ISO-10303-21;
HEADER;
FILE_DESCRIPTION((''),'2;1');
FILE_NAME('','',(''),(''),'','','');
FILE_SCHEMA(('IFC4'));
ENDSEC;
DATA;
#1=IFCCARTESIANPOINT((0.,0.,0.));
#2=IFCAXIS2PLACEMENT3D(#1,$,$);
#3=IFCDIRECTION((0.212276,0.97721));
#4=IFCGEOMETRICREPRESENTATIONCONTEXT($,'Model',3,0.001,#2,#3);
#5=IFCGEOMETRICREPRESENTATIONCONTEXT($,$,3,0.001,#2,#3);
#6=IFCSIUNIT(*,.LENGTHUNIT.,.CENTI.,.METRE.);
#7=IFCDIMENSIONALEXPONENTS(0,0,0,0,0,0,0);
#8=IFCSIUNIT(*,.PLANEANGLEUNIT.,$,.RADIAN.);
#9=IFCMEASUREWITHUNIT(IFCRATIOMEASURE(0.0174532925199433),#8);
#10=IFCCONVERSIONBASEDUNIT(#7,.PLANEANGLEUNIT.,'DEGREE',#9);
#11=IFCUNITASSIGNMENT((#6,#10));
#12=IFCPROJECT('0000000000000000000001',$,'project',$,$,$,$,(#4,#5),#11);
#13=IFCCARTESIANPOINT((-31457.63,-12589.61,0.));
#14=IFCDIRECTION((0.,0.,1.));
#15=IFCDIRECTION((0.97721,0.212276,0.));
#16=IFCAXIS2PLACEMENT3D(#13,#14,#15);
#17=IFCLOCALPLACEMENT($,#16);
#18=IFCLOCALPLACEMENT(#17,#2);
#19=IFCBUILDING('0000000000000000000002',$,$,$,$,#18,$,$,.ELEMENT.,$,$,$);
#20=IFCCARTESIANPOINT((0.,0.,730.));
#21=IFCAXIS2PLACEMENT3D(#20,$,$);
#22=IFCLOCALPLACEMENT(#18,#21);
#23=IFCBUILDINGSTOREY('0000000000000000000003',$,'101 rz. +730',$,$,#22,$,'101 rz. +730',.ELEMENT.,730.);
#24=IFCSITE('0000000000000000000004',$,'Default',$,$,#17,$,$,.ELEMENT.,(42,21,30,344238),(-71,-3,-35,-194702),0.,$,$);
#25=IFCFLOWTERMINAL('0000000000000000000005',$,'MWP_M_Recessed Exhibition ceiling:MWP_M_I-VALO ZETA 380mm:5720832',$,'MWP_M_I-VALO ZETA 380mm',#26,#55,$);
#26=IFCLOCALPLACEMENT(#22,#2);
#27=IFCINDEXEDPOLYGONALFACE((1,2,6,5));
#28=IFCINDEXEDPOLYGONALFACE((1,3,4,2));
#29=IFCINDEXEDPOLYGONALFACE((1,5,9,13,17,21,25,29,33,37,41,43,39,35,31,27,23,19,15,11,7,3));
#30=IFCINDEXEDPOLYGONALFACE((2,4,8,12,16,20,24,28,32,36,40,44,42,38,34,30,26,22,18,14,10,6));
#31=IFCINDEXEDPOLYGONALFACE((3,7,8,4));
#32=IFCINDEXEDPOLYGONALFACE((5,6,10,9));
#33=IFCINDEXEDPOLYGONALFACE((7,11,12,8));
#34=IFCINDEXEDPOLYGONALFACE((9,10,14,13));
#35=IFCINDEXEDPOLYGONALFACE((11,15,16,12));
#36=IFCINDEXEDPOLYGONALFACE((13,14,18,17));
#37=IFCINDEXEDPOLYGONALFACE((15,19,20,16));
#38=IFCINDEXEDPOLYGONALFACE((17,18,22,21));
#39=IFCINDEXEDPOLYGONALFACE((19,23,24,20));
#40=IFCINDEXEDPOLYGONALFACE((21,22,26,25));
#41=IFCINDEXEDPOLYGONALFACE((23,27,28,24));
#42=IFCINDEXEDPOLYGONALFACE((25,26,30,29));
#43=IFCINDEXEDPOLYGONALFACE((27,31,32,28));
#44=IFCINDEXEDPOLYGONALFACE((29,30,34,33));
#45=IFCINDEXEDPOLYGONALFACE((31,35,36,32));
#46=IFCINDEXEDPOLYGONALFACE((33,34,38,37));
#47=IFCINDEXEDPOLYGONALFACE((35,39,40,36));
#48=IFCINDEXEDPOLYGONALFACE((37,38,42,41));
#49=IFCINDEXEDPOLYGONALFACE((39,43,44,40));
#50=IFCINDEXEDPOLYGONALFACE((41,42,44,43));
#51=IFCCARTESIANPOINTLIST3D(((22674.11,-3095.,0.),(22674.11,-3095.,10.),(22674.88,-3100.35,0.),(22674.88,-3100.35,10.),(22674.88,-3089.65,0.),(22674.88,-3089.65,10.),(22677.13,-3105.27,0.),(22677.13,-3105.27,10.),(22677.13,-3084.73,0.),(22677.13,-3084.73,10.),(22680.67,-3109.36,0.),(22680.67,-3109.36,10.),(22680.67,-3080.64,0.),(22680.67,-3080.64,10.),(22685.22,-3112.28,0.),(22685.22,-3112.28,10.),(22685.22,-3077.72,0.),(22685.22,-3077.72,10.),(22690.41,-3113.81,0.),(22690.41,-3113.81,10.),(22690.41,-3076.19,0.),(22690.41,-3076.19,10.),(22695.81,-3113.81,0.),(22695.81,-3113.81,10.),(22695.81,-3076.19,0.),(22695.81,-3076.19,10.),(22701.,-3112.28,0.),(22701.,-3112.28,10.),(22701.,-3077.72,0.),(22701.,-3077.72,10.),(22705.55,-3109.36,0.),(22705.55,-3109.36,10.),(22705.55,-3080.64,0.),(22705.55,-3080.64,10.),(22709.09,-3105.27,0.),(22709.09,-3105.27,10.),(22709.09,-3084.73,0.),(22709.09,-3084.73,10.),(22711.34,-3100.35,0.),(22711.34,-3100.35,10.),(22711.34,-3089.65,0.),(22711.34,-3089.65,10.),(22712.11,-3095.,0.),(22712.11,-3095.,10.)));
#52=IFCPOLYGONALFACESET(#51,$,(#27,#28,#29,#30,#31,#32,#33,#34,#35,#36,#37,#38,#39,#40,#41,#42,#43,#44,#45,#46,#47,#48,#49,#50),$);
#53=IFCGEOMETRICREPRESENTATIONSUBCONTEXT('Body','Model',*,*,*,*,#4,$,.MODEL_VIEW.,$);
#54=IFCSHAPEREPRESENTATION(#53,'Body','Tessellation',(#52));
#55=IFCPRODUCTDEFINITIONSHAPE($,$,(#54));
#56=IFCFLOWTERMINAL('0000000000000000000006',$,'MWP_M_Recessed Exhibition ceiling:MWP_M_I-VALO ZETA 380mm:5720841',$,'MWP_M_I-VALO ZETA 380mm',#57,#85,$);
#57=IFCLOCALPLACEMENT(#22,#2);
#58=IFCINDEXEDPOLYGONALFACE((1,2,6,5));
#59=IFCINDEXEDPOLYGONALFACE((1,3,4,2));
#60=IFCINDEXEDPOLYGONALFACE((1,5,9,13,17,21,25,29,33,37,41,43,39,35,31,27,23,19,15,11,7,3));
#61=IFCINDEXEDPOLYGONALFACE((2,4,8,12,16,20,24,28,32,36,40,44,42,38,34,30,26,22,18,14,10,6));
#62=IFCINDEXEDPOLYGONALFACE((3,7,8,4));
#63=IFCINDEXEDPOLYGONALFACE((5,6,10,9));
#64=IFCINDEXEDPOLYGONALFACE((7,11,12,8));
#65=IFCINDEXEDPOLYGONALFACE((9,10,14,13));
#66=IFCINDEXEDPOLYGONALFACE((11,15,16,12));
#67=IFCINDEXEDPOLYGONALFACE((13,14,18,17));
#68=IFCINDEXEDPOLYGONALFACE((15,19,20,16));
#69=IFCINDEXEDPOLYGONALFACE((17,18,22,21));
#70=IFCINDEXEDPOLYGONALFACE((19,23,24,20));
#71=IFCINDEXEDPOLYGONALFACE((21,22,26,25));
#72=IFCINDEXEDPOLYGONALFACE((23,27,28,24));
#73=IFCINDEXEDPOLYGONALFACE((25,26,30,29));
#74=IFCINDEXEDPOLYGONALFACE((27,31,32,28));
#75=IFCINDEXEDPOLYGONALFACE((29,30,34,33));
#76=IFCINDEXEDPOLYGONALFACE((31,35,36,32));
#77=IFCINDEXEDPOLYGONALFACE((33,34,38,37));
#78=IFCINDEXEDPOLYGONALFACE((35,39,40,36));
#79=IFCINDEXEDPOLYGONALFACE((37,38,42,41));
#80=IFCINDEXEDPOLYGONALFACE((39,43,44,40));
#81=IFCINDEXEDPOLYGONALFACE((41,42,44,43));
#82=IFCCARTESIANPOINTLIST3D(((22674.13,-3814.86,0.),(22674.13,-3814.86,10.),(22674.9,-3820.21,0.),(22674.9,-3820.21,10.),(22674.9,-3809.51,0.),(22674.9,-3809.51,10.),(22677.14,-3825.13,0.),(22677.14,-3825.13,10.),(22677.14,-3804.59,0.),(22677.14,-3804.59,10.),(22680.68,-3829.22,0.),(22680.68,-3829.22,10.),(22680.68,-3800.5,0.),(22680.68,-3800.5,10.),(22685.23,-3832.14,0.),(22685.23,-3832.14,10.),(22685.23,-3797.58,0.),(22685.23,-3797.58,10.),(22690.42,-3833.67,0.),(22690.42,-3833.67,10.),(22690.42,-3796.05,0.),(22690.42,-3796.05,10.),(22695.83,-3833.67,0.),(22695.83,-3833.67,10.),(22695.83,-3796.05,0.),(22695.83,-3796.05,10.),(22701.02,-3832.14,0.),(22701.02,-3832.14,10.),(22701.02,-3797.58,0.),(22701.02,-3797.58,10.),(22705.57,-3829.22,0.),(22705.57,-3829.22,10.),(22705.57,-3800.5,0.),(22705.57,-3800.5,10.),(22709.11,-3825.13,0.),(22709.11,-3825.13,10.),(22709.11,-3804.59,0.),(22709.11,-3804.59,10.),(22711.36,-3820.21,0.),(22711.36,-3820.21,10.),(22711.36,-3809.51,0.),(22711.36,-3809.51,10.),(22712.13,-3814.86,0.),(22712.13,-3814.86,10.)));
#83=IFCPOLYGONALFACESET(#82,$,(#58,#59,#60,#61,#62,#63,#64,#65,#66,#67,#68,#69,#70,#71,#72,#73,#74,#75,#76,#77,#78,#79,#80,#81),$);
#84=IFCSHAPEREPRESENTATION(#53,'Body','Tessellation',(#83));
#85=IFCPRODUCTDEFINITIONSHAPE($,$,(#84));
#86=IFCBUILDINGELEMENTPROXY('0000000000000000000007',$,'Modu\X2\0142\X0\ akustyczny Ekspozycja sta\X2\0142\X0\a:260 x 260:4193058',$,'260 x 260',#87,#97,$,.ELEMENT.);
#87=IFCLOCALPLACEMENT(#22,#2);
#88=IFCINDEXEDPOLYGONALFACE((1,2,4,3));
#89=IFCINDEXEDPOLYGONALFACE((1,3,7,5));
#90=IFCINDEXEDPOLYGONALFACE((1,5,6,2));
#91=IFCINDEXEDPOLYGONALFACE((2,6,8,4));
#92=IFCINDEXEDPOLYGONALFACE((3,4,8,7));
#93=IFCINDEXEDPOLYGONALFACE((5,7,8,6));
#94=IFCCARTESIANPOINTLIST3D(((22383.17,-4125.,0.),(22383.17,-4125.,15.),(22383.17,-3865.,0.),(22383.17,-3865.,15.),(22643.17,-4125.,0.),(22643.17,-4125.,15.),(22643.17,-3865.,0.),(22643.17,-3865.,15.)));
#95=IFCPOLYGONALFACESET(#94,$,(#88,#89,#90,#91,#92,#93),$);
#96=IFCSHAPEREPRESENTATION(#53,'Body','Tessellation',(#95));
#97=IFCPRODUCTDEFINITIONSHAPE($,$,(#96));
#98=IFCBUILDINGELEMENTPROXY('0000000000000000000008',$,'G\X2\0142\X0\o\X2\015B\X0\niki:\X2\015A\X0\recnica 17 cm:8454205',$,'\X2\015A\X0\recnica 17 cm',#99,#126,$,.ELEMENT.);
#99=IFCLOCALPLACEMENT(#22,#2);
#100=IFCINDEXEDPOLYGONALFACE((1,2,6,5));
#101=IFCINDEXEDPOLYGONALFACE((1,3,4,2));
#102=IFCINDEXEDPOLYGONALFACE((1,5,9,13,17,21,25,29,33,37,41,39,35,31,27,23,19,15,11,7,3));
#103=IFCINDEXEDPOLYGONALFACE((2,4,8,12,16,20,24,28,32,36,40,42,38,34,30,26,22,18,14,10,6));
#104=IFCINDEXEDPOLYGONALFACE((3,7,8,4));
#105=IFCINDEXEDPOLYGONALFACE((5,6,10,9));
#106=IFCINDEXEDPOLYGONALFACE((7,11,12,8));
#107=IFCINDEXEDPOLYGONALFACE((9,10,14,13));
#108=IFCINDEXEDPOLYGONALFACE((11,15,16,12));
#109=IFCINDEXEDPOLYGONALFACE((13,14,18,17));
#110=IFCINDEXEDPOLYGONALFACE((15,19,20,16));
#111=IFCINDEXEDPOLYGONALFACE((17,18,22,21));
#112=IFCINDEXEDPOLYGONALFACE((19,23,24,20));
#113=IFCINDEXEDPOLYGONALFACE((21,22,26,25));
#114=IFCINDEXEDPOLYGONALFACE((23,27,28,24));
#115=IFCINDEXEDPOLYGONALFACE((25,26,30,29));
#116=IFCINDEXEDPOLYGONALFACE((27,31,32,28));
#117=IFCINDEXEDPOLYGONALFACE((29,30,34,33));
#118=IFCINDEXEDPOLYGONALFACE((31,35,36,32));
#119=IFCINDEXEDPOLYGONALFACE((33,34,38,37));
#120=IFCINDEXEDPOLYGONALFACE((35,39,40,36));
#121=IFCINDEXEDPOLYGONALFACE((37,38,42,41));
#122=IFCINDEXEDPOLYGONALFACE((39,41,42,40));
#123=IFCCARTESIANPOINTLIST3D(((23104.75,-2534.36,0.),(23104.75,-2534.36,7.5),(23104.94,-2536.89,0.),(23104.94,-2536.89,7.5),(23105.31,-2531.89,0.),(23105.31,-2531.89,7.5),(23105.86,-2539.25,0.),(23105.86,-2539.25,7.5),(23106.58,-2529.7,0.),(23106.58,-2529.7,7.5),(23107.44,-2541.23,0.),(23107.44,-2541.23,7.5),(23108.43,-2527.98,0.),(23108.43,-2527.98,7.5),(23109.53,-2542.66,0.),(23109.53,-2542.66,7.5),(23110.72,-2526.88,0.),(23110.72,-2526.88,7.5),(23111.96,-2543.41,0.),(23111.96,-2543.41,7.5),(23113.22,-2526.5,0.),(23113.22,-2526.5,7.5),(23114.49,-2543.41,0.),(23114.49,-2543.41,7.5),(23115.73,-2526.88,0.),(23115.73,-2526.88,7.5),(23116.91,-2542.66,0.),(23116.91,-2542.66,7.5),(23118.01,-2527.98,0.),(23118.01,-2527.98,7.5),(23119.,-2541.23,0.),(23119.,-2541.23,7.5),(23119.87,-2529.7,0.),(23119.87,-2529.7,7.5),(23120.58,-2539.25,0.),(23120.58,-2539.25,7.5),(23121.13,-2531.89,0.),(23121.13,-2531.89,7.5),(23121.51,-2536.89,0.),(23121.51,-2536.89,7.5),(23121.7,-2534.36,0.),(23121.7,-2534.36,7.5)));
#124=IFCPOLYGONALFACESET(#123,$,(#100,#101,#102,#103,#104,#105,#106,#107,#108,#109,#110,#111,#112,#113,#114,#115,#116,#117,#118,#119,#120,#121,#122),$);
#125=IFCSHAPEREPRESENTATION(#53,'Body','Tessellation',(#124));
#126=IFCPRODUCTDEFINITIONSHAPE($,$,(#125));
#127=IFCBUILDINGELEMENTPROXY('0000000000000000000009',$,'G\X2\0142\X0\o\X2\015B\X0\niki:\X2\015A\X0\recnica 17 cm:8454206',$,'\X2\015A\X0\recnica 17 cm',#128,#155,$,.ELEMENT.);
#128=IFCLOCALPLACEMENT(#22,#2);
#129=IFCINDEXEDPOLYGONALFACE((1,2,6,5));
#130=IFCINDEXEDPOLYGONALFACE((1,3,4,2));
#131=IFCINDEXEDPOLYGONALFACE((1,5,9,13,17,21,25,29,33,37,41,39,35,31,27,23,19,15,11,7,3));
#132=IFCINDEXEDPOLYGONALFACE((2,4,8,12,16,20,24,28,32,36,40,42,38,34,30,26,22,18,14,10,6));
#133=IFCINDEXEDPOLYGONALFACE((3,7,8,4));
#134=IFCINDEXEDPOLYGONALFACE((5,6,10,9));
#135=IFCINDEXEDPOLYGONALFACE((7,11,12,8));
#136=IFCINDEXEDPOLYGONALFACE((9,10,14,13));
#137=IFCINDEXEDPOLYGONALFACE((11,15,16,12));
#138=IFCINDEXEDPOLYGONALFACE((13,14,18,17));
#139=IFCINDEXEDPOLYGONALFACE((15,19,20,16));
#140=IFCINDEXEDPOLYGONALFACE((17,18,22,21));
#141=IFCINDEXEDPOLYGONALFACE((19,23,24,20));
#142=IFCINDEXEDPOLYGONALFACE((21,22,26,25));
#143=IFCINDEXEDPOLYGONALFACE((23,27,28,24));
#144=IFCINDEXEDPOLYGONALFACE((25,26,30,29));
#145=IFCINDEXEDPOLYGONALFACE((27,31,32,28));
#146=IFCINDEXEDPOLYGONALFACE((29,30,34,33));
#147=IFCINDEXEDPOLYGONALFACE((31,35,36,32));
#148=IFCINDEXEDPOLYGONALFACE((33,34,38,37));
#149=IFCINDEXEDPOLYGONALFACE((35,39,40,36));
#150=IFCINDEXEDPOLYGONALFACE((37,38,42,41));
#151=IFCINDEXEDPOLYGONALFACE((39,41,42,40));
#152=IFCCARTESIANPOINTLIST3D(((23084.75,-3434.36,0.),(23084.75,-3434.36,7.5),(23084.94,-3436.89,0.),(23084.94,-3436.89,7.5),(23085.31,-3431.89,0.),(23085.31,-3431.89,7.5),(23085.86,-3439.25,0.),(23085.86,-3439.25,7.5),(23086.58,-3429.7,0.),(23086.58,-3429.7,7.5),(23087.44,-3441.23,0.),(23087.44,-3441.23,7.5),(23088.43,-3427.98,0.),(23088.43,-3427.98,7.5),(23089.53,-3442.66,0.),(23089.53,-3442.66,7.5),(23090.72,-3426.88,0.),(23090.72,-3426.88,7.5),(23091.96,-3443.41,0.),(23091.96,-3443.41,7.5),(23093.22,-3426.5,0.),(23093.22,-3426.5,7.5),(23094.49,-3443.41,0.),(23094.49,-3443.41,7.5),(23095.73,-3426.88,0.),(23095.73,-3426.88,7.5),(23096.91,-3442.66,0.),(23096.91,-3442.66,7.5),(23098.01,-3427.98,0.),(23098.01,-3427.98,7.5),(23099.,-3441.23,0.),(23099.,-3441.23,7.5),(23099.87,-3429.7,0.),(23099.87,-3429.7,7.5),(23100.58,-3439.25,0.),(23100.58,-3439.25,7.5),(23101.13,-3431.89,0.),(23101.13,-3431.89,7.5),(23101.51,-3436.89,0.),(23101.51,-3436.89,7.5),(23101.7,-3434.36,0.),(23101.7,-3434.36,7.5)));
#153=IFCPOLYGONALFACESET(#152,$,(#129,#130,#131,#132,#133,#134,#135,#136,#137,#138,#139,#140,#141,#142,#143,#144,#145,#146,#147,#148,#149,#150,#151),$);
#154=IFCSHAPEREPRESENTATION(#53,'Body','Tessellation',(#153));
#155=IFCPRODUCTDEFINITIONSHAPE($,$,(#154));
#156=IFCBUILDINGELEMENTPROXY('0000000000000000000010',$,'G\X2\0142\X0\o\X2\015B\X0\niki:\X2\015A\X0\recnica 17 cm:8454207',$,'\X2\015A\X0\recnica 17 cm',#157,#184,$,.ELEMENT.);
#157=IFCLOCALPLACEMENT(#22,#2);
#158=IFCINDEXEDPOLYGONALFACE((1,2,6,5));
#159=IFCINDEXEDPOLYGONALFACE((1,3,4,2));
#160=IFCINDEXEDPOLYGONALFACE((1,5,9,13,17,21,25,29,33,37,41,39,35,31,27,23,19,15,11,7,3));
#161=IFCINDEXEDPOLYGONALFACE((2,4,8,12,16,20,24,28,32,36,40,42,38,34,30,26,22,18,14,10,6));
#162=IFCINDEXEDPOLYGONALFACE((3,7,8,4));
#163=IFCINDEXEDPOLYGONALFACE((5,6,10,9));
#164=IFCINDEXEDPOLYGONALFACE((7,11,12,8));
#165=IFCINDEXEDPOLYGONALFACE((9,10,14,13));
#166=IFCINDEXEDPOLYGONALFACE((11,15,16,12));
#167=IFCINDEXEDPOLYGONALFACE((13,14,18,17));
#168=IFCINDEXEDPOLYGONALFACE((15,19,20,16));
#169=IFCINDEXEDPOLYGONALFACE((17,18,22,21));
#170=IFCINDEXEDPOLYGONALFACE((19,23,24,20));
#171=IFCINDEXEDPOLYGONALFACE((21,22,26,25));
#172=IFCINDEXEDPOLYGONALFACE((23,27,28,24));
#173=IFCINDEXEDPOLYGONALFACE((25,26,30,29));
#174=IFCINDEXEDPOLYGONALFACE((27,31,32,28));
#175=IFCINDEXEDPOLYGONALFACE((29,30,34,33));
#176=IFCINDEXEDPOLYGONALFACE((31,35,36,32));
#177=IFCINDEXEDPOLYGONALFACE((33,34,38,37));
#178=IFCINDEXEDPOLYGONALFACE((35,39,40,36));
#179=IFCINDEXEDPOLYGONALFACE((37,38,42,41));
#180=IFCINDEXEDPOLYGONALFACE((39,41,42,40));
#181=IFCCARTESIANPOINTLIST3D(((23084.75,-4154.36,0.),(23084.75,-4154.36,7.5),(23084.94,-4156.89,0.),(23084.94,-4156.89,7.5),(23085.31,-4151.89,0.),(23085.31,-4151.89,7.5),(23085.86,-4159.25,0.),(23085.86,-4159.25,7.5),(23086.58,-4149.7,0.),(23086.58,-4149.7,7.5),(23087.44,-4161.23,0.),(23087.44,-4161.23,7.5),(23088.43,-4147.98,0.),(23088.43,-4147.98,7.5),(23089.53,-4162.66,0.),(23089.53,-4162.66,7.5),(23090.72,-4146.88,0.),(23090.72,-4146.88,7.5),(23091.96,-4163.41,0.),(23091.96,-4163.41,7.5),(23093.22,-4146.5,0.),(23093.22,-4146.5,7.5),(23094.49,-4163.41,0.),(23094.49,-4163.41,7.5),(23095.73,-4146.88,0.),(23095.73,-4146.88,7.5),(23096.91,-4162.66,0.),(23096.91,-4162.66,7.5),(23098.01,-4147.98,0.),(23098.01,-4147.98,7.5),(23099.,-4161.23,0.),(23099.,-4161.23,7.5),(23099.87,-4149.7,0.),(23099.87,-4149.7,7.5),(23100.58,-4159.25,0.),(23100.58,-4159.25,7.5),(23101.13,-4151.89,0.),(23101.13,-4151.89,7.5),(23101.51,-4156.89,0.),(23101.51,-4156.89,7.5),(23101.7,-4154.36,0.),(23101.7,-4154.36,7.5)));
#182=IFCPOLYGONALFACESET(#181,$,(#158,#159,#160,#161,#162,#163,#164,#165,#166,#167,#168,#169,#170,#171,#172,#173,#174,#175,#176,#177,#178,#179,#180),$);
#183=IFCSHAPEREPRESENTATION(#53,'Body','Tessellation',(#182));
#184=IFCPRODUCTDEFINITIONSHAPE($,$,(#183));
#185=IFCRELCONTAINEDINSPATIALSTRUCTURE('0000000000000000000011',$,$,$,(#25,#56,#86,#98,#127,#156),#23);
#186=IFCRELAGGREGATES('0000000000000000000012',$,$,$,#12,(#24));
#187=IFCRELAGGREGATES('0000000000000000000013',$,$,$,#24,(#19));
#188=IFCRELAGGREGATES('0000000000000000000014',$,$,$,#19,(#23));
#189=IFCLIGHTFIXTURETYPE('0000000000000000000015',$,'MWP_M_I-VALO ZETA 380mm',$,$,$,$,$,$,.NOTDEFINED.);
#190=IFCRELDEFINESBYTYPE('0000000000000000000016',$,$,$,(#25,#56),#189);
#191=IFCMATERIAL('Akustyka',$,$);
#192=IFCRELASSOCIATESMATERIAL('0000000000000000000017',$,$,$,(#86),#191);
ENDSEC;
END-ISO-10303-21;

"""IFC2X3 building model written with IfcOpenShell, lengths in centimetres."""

from ifc_helpers import new_model, entity, si_unit, converted_unit, direction, frame, frame_2d, origin, origin_2d_with_axis, place, context, subcontext, project, spatial, rectangle, circle, extrude, source, transform, mapped, material, type_object, type_shapes, element, save


model = new_model("IFC2X3")

# Units and contexts
model_context = context("Model", 3, precision=0.001, world=origin(), true_north=direction((0.212276, 0.97721)))
context_of_model = context(None, 3, precision=0.001, world=origin(), true_north=direction((0.212276, 0.97721)))
body_context = subcontext(model_context, "Body", "Model", "MODEL_VIEW")
ifc_project = project(units=[si_unit("LENGTHUNIT", "METRE", prefix="CENTI"), converted_unit("PLANEANGLEUNIT", "DEGREE", entity("IfcRatioMeasure", 0.0174532925199433), si_unit("PLANEANGLEUNIT", "RADIAN"), dimensions=[0, 0, 0, 0, 0, 0, 0])], contexts=[model_context, context_of_model])

# Site, building, storey
site_placement = place(None, frame((-31457.63, -12589.61, 0.0), z_axis=(0.0, 0.0, 1.0), x_axis=(0.97721, 0.212276, 0.0)))
site = spatial("IfcSite", under=ifc_project, at=site_placement, Name="Default", CompositionType="ELEMENT", RefLatitude=(42, 21, 30, 344238), RefLongitude=(-71, -3, -35, -194702), RefElevation=0.0)
building_placement = place(site_placement, origin())
building = spatial("IfcBuilding", under=site, at=building_placement, CompositionType="ELEMENT")
storey_placement = place(building_placement, frame((0.0, 0.0, 730.0)))
storey = spatial("IfcBuildingStorey", under=building, at=storey_placement, Name="101 rz. +730", LongName="101 rz. +730", CompositionType="ELEMENT", Elevation=730.0)

# Flow terminals
light_fixture_type = type_object("IfcLightFixtureType", Name="MWP_M_I-VALO ZETA 380mm", PredefinedType="NOTDEFINED")
shared_shape_1 = source(origin(), body_context, "Body", "SweptSolid", [
    extrude(circle(Radius=19.0, at=frame_2d((0.0, 0.0), x_axis=(1.0, 0.0))), frame((0.0, 0.0, -10.0)), (0.0, 0.0, 1.0), 10.0),
])
type_shapes(light_fixture_type, [shared_shape_1])
for number, where, z_axis, x_axis, name in (
    (1, (22693.11, -3095.0, 0.0), (0.0, 0.0, -1.0), (1.0, 0.0, 0.0), "MWP_M_Recessed Exhibition ceiling:MWP_M_I-VALO ZETA 380mm:5720832"),
    (2, (22693.13, -3814.86, 0.0), (0.0, 0.0, -1.0), (1.0, 0.0, 0.0), "MWP_M_Recessed Exhibition ceiling:MWP_M_I-VALO ZETA 380mm:5720841"),
):
    element("IfcFlowTerminal", number, at=place(storey_placement, frame(where, z_axis=z_axis, x_axis=x_axis)), inside=storey, type_object=light_fixture_type, Name=name, ObjectType="MWP_M_I-VALO ZETA 380mm", context=body_context, shape_type="MappedRepresentation", body=[
        mapped(shared_shape_1, transform((0.0, 0.0, 0.0), scale=1.0)),
    ])

# Building element proxies
ifc_material_1 = material(Name="Akustyka")
shared_shape_2 = source(origin(), body_context, "Body", "SweptSolid", [
    extrude(rectangle(XDim=260.0, YDim=260.0, at=origin_2d_with_axis()), frame((0.0, 0.0, -15.0), z_axis=(0.0, 0.0, 1.0), x_axis=(-1.0, 0.0, 0.0)), (0.0, 0.0, 1.0), 15.0),
])
proxy_placement = place(storey_placement, frame((22513.17, -3995.0, 0.0), z_axis=(0.0, 0.0, -1.0), x_axis=(1.0, 0.0, 0.0)))
element("IfcBuildingElementProxy", 3, at=proxy_placement, inside=storey, material=ifc_material_1, Name="Moduł akustyczny Ekspozycja stała:260 x 260:4193058", ObjectType="260 x 260", CompositionType="ELEMENT", context=body_context, shape_type="MappedRepresentation", body=[
    mapped(shared_shape_2, transform((0.0, 0.0, 0.0), scale=1.0)),
])
shared_shape_3 = source(origin(), body_context, "Body", "SweptSolid", [
    extrude(circle(Radius=8.5, at=frame_2d((0.0, 0.0), x_axis=(1.0, 0.0))), frame((0.0, 0.0, 0.0), z_axis=(0.0, 0.0, 1.0), x_axis=(0.0, 1.0, 0.0)), (0.0, 0.0, 1.0), 7.5),
])
for number, where, name in (
    (4, (23113.22, -2535.0, 0.0), "Głośniki:Śrecnica 17 cm:8454205"),
    (5, (23093.22, -3435.0, 0.0), "Głośniki:Śrecnica 17 cm:8454206"),
    (6, (23093.22, -4155.0, 0.0), "Głośniki:Śrecnica 17 cm:8454207"),
):
    element("IfcBuildingElementProxy", number, at=place(storey_placement, frame(where)), inside=storey, Name=name, ObjectType="Śrecnica 17 cm", CompositionType="ELEMENT", context=body_context, shape_type="MappedRepresentation", body=[
        mapped(shared_shape_3, transform((0.0, 0.0, 0.0), scale=1.0)),
    ])

save(model, "model.ifc")
